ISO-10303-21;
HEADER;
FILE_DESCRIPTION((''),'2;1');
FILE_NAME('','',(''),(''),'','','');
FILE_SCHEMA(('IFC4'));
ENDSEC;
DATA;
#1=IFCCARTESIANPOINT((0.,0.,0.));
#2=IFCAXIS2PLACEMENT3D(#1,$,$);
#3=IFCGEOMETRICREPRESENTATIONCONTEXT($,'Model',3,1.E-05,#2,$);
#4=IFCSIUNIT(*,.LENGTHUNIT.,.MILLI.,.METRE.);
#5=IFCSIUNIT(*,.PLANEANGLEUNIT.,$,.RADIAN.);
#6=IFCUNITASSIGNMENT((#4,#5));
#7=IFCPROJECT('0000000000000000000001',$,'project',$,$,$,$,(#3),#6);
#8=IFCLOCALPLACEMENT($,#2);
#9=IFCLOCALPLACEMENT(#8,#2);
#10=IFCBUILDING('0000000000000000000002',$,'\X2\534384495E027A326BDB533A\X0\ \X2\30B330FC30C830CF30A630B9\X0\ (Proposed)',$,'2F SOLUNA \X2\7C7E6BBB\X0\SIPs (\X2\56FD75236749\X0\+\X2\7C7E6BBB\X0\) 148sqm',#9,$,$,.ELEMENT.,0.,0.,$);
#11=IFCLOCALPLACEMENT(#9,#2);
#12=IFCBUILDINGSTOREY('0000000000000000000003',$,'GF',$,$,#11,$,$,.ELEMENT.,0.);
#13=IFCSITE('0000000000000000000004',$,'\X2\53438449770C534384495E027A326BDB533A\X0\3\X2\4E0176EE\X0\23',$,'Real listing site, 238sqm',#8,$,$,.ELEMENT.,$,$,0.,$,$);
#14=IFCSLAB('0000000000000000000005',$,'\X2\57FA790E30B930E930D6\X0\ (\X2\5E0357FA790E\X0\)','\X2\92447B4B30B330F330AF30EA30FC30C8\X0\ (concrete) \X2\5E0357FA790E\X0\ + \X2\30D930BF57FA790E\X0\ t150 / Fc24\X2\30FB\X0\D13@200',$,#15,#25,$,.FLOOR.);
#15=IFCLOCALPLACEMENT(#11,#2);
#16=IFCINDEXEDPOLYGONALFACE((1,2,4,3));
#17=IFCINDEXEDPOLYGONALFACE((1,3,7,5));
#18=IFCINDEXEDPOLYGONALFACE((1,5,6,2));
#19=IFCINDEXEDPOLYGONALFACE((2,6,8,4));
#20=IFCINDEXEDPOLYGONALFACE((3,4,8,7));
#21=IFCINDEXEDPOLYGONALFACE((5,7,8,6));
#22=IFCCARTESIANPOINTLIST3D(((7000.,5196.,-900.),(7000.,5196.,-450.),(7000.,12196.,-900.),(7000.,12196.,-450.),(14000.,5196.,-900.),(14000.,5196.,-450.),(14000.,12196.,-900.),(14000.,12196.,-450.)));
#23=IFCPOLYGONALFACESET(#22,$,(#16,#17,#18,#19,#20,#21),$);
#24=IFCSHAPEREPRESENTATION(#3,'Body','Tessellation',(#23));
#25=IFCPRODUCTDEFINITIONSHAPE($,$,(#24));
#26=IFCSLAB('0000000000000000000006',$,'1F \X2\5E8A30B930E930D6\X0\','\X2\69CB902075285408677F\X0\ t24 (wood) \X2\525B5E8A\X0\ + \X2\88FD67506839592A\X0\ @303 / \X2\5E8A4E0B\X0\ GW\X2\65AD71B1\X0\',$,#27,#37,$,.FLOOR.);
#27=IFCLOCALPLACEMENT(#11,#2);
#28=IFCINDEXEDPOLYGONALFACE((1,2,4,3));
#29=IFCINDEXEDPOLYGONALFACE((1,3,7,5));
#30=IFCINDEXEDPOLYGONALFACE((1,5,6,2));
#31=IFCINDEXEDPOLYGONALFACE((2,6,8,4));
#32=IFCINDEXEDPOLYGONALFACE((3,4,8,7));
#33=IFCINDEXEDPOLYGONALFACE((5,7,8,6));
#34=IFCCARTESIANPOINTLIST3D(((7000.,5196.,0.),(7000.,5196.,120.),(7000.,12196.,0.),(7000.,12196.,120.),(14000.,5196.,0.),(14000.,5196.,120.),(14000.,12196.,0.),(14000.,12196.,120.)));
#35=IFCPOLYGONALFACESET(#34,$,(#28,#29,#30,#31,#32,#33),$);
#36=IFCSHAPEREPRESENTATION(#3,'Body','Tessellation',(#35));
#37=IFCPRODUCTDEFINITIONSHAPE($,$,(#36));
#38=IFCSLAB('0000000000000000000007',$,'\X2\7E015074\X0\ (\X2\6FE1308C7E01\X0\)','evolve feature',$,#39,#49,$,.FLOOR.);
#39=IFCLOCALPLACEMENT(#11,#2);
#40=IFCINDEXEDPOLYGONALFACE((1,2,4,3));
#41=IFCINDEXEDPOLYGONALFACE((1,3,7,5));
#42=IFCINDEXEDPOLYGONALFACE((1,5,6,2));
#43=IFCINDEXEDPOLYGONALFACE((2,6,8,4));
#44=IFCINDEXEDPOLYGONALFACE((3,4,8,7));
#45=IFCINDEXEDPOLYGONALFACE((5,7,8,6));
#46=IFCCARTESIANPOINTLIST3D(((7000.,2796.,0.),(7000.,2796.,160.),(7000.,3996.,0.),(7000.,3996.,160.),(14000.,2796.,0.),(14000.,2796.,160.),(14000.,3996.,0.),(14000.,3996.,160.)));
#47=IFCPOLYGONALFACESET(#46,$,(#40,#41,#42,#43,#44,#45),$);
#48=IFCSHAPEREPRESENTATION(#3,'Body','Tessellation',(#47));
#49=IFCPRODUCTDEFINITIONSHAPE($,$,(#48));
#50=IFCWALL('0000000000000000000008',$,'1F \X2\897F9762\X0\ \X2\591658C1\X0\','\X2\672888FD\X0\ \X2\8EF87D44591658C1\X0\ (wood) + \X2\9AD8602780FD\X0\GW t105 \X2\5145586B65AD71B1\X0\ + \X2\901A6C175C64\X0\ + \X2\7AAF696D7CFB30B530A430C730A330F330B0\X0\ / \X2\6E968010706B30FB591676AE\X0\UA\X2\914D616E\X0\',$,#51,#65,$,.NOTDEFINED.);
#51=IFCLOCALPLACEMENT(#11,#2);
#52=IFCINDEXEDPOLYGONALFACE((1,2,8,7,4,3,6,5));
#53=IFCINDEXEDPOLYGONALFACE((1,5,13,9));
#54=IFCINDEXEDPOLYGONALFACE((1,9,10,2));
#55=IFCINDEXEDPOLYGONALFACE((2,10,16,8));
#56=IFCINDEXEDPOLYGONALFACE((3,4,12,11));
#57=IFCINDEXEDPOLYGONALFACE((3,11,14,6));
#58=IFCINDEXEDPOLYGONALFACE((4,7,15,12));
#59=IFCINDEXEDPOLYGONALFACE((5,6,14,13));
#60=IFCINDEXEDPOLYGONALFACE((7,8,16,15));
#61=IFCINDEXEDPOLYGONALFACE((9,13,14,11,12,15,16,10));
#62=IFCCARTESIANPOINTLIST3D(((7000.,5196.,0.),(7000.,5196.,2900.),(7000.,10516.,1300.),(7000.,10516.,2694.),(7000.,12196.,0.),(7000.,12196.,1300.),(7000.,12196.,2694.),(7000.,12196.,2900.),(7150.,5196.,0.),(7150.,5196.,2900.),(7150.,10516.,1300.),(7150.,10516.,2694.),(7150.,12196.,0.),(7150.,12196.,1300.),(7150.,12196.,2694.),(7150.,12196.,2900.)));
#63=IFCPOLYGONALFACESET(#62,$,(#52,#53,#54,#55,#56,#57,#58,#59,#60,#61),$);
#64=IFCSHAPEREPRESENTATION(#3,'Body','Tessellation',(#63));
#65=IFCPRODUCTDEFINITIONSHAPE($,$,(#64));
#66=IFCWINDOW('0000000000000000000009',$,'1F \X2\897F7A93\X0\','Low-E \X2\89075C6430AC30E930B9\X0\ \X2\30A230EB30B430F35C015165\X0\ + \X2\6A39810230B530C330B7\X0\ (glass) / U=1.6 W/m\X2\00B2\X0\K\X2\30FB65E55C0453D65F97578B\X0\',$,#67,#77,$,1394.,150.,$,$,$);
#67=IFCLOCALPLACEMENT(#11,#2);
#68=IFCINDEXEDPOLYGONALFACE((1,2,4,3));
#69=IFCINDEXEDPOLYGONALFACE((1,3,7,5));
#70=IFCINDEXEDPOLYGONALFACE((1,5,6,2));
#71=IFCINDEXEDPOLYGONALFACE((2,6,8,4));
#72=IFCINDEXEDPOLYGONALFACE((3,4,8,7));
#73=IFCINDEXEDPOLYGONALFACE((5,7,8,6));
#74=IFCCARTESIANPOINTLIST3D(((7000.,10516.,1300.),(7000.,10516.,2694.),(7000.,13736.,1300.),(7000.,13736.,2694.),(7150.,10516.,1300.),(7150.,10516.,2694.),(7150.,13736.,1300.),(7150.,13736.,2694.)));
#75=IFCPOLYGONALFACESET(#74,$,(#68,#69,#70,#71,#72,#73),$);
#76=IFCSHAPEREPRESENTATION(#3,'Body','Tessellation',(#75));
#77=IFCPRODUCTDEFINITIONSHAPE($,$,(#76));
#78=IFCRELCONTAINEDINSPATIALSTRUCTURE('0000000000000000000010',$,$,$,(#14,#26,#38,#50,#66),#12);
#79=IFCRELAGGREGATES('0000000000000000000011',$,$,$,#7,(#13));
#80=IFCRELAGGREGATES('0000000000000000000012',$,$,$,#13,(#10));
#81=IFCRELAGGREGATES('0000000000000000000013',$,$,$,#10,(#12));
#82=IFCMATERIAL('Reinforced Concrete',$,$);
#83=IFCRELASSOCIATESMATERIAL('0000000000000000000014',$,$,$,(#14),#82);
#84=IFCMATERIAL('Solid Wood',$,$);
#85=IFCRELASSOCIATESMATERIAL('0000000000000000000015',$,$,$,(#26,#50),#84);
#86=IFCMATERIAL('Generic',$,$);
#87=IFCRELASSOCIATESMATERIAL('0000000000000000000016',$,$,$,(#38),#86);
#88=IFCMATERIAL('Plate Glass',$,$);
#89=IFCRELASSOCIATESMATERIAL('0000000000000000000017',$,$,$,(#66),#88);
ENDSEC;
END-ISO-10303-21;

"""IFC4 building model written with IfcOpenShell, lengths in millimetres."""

from ifc_helpers import new_model, si_unit, frame, frame_2d, origin, place, context, project, spatial, rectangle, extrude, material, element, fill, save


model = new_model("IFC4")

# Units and contexts
model_context = context("Model", 3, precision=1e-05, world=origin())
ifc_project = project(units=[si_unit("LENGTHUNIT", "METRE", prefix="MILLI"), si_unit("PLANEANGLEUNIT", "RADIAN")], contexts=[model_context])

# Site, building, storey
site_placement = place(None, origin())
site = spatial("IfcSite", under=ifc_project, at=site_placement, Name="千葉県千葉市稲毛区3丁目23", ObjectType="Real listing site, 238sqm", CompositionType="ELEMENT", RefElevation=0.0)
building_placement = place(site_placement, origin())
building = spatial("IfcBuilding", under=site, at=building_placement, Name="千葉市稲毛区 コートハウス (Proposed)", ObjectType="2F SOLUNA 籾殻SIPs (国産杉+籾殻) 148sqm", CompositionType="ELEMENT", ElevationOfRefHeight=0.0, ElevationOfTerrain=0.0)
storey_placement = place(building_placement, origin())
storey = spatial("IfcBuildingStorey", under=building, at=storey_placement, Name="GF", CompositionType="ELEMENT", Elevation=0.0)

# Slabs
ifc_material_1 = material(Name="Reinforced Concrete")
slab_1_placement = place(storey_placement, frame((3500.0, 2598.0, -450.0)))
element("IfcSlab", 1, at=slab_1_placement, inside=storey, material=ifc_material_1, Name="基礎スラブ (布基礎)", Description="鉄筋コンクリート (concrete) 布基礎 + ベタ基礎 t150 / Fc24・D13@200", PredefinedType="FLOOR", context=model_context, shape_type="SweptSolid", body=[
    extrude(rectangle(XDim=7000.0, YDim=7000.0, at=frame_2d((3500.0, 3500.0))), frame((3500.0, 2598.0, -450.0)), (0.0, 0.0, 1.0), 450.0),
])
ifc_material_2 = material(Name="Solid Wood")
slab_2_placement = place(storey_placement, frame((3500.0, 2598.0, 0.0)))
element("IfcSlab", 2, at=slab_2_placement, inside=storey, material=ifc_material_2, Name="1F 床スラブ", Description="構造用合板 t24 (wood) 剛床 + 製材根太 @303 / 床下 GW断熱", PredefinedType="FLOOR", context=model_context, shape_type="SweptSolid", body=[
    extrude(rectangle(XDim=7000.0, YDim=7000.0, at=frame_2d((3500.0, 3500.0))), frame((3500.0, 2598.0, 0.0)), (0.0, 0.0, 1.0), 120.0),
])
ifc_material_3 = material(Name="Generic")
slab_3_placement = place(storey_placement, frame((3500.0, 1398.0, 0.0)))
element("IfcSlab", 3, at=slab_3_placement, inside=storey, material=ifc_material_3, Name="縁側 (濡れ縁)", Description="evolve feature", PredefinedType="FLOOR", context=model_context, shape_type="SweptSolid", body=[
    extrude(rectangle(XDim=7000.0, YDim=1200.0, at=frame_2d((3500.0, 600.0))), frame((3500.0, 1398.0, 0.0)), (0.0, 0.0, 1.0), 160.0),
])

# Shared definitions
ifc_material_4 = material(Name="Plate Glass")

# Wall, opening, window
wall_1_placement = place(storey_placement, frame((3500.0, 2598.0, 0.0)))
wall_1 = element("IfcWall", 4, at=wall_1_placement, inside=storey, material=ifc_material_2, Name="1F 西面 外壁", Description="木製 軸組外壁 (wood) + 高性能GW t105 充填断熱 + 通気層 + 窯業系サイディング / 準耐火・外皮UA配慮", PredefinedType="NOTDEFINED", context=model_context, shape_type="SweptSolid", body=[
    extrude(rectangle(XDim=150.0, YDim=7000.0, at=frame_2d((75.0, 3500.0))), frame((3500.0, 2598.0, 0.0)), (0.0, 0.0, 1.0), 2900.0),
])
opening_1_placement = place(storey_placement, frame((3500.0, 5258.0, 650.0)))
opening_1 = element("IfcOpeningElement", 5, at=opening_1_placement, cuts=wall_1, PredefinedType="NOTDEFINED", context=model_context, shape_type="SweptSolid", body=[
    extrude(rectangle(XDim=150.0, YDim=3220.0, at=frame_2d((75.0, 1610.0))), frame((3500.0, 5258.0, 650.0)), (0.0, 0.0, 1.0), 1394.0),
])
window_1_placement = place(storey_placement, frame((3500.0, 5258.0, 650.0)))
window_1 = element("IfcWindow", 6, at=window_1_placement, inside=storey, material=ifc_material_4, Name="1F 西窓", Description="Low-E 複層ガラス アルゴン封入 + 樹脂サッシ (glass) / U=1.6 W/m²K・日射取得型", OverallHeight=1394.0, OverallWidth=150.0, context=model_context, shape_type="SweptSolid", body=[
    extrude(rectangle(XDim=150.0, YDim=3220.0, at=frame_2d((75.0, 1610.0))), frame((3500.0, 5258.0, 650.0)), (0.0, 0.0, 1.0), 1394.0),
])
fill(opening_1, window_1)

save(model, "model.ifc")
